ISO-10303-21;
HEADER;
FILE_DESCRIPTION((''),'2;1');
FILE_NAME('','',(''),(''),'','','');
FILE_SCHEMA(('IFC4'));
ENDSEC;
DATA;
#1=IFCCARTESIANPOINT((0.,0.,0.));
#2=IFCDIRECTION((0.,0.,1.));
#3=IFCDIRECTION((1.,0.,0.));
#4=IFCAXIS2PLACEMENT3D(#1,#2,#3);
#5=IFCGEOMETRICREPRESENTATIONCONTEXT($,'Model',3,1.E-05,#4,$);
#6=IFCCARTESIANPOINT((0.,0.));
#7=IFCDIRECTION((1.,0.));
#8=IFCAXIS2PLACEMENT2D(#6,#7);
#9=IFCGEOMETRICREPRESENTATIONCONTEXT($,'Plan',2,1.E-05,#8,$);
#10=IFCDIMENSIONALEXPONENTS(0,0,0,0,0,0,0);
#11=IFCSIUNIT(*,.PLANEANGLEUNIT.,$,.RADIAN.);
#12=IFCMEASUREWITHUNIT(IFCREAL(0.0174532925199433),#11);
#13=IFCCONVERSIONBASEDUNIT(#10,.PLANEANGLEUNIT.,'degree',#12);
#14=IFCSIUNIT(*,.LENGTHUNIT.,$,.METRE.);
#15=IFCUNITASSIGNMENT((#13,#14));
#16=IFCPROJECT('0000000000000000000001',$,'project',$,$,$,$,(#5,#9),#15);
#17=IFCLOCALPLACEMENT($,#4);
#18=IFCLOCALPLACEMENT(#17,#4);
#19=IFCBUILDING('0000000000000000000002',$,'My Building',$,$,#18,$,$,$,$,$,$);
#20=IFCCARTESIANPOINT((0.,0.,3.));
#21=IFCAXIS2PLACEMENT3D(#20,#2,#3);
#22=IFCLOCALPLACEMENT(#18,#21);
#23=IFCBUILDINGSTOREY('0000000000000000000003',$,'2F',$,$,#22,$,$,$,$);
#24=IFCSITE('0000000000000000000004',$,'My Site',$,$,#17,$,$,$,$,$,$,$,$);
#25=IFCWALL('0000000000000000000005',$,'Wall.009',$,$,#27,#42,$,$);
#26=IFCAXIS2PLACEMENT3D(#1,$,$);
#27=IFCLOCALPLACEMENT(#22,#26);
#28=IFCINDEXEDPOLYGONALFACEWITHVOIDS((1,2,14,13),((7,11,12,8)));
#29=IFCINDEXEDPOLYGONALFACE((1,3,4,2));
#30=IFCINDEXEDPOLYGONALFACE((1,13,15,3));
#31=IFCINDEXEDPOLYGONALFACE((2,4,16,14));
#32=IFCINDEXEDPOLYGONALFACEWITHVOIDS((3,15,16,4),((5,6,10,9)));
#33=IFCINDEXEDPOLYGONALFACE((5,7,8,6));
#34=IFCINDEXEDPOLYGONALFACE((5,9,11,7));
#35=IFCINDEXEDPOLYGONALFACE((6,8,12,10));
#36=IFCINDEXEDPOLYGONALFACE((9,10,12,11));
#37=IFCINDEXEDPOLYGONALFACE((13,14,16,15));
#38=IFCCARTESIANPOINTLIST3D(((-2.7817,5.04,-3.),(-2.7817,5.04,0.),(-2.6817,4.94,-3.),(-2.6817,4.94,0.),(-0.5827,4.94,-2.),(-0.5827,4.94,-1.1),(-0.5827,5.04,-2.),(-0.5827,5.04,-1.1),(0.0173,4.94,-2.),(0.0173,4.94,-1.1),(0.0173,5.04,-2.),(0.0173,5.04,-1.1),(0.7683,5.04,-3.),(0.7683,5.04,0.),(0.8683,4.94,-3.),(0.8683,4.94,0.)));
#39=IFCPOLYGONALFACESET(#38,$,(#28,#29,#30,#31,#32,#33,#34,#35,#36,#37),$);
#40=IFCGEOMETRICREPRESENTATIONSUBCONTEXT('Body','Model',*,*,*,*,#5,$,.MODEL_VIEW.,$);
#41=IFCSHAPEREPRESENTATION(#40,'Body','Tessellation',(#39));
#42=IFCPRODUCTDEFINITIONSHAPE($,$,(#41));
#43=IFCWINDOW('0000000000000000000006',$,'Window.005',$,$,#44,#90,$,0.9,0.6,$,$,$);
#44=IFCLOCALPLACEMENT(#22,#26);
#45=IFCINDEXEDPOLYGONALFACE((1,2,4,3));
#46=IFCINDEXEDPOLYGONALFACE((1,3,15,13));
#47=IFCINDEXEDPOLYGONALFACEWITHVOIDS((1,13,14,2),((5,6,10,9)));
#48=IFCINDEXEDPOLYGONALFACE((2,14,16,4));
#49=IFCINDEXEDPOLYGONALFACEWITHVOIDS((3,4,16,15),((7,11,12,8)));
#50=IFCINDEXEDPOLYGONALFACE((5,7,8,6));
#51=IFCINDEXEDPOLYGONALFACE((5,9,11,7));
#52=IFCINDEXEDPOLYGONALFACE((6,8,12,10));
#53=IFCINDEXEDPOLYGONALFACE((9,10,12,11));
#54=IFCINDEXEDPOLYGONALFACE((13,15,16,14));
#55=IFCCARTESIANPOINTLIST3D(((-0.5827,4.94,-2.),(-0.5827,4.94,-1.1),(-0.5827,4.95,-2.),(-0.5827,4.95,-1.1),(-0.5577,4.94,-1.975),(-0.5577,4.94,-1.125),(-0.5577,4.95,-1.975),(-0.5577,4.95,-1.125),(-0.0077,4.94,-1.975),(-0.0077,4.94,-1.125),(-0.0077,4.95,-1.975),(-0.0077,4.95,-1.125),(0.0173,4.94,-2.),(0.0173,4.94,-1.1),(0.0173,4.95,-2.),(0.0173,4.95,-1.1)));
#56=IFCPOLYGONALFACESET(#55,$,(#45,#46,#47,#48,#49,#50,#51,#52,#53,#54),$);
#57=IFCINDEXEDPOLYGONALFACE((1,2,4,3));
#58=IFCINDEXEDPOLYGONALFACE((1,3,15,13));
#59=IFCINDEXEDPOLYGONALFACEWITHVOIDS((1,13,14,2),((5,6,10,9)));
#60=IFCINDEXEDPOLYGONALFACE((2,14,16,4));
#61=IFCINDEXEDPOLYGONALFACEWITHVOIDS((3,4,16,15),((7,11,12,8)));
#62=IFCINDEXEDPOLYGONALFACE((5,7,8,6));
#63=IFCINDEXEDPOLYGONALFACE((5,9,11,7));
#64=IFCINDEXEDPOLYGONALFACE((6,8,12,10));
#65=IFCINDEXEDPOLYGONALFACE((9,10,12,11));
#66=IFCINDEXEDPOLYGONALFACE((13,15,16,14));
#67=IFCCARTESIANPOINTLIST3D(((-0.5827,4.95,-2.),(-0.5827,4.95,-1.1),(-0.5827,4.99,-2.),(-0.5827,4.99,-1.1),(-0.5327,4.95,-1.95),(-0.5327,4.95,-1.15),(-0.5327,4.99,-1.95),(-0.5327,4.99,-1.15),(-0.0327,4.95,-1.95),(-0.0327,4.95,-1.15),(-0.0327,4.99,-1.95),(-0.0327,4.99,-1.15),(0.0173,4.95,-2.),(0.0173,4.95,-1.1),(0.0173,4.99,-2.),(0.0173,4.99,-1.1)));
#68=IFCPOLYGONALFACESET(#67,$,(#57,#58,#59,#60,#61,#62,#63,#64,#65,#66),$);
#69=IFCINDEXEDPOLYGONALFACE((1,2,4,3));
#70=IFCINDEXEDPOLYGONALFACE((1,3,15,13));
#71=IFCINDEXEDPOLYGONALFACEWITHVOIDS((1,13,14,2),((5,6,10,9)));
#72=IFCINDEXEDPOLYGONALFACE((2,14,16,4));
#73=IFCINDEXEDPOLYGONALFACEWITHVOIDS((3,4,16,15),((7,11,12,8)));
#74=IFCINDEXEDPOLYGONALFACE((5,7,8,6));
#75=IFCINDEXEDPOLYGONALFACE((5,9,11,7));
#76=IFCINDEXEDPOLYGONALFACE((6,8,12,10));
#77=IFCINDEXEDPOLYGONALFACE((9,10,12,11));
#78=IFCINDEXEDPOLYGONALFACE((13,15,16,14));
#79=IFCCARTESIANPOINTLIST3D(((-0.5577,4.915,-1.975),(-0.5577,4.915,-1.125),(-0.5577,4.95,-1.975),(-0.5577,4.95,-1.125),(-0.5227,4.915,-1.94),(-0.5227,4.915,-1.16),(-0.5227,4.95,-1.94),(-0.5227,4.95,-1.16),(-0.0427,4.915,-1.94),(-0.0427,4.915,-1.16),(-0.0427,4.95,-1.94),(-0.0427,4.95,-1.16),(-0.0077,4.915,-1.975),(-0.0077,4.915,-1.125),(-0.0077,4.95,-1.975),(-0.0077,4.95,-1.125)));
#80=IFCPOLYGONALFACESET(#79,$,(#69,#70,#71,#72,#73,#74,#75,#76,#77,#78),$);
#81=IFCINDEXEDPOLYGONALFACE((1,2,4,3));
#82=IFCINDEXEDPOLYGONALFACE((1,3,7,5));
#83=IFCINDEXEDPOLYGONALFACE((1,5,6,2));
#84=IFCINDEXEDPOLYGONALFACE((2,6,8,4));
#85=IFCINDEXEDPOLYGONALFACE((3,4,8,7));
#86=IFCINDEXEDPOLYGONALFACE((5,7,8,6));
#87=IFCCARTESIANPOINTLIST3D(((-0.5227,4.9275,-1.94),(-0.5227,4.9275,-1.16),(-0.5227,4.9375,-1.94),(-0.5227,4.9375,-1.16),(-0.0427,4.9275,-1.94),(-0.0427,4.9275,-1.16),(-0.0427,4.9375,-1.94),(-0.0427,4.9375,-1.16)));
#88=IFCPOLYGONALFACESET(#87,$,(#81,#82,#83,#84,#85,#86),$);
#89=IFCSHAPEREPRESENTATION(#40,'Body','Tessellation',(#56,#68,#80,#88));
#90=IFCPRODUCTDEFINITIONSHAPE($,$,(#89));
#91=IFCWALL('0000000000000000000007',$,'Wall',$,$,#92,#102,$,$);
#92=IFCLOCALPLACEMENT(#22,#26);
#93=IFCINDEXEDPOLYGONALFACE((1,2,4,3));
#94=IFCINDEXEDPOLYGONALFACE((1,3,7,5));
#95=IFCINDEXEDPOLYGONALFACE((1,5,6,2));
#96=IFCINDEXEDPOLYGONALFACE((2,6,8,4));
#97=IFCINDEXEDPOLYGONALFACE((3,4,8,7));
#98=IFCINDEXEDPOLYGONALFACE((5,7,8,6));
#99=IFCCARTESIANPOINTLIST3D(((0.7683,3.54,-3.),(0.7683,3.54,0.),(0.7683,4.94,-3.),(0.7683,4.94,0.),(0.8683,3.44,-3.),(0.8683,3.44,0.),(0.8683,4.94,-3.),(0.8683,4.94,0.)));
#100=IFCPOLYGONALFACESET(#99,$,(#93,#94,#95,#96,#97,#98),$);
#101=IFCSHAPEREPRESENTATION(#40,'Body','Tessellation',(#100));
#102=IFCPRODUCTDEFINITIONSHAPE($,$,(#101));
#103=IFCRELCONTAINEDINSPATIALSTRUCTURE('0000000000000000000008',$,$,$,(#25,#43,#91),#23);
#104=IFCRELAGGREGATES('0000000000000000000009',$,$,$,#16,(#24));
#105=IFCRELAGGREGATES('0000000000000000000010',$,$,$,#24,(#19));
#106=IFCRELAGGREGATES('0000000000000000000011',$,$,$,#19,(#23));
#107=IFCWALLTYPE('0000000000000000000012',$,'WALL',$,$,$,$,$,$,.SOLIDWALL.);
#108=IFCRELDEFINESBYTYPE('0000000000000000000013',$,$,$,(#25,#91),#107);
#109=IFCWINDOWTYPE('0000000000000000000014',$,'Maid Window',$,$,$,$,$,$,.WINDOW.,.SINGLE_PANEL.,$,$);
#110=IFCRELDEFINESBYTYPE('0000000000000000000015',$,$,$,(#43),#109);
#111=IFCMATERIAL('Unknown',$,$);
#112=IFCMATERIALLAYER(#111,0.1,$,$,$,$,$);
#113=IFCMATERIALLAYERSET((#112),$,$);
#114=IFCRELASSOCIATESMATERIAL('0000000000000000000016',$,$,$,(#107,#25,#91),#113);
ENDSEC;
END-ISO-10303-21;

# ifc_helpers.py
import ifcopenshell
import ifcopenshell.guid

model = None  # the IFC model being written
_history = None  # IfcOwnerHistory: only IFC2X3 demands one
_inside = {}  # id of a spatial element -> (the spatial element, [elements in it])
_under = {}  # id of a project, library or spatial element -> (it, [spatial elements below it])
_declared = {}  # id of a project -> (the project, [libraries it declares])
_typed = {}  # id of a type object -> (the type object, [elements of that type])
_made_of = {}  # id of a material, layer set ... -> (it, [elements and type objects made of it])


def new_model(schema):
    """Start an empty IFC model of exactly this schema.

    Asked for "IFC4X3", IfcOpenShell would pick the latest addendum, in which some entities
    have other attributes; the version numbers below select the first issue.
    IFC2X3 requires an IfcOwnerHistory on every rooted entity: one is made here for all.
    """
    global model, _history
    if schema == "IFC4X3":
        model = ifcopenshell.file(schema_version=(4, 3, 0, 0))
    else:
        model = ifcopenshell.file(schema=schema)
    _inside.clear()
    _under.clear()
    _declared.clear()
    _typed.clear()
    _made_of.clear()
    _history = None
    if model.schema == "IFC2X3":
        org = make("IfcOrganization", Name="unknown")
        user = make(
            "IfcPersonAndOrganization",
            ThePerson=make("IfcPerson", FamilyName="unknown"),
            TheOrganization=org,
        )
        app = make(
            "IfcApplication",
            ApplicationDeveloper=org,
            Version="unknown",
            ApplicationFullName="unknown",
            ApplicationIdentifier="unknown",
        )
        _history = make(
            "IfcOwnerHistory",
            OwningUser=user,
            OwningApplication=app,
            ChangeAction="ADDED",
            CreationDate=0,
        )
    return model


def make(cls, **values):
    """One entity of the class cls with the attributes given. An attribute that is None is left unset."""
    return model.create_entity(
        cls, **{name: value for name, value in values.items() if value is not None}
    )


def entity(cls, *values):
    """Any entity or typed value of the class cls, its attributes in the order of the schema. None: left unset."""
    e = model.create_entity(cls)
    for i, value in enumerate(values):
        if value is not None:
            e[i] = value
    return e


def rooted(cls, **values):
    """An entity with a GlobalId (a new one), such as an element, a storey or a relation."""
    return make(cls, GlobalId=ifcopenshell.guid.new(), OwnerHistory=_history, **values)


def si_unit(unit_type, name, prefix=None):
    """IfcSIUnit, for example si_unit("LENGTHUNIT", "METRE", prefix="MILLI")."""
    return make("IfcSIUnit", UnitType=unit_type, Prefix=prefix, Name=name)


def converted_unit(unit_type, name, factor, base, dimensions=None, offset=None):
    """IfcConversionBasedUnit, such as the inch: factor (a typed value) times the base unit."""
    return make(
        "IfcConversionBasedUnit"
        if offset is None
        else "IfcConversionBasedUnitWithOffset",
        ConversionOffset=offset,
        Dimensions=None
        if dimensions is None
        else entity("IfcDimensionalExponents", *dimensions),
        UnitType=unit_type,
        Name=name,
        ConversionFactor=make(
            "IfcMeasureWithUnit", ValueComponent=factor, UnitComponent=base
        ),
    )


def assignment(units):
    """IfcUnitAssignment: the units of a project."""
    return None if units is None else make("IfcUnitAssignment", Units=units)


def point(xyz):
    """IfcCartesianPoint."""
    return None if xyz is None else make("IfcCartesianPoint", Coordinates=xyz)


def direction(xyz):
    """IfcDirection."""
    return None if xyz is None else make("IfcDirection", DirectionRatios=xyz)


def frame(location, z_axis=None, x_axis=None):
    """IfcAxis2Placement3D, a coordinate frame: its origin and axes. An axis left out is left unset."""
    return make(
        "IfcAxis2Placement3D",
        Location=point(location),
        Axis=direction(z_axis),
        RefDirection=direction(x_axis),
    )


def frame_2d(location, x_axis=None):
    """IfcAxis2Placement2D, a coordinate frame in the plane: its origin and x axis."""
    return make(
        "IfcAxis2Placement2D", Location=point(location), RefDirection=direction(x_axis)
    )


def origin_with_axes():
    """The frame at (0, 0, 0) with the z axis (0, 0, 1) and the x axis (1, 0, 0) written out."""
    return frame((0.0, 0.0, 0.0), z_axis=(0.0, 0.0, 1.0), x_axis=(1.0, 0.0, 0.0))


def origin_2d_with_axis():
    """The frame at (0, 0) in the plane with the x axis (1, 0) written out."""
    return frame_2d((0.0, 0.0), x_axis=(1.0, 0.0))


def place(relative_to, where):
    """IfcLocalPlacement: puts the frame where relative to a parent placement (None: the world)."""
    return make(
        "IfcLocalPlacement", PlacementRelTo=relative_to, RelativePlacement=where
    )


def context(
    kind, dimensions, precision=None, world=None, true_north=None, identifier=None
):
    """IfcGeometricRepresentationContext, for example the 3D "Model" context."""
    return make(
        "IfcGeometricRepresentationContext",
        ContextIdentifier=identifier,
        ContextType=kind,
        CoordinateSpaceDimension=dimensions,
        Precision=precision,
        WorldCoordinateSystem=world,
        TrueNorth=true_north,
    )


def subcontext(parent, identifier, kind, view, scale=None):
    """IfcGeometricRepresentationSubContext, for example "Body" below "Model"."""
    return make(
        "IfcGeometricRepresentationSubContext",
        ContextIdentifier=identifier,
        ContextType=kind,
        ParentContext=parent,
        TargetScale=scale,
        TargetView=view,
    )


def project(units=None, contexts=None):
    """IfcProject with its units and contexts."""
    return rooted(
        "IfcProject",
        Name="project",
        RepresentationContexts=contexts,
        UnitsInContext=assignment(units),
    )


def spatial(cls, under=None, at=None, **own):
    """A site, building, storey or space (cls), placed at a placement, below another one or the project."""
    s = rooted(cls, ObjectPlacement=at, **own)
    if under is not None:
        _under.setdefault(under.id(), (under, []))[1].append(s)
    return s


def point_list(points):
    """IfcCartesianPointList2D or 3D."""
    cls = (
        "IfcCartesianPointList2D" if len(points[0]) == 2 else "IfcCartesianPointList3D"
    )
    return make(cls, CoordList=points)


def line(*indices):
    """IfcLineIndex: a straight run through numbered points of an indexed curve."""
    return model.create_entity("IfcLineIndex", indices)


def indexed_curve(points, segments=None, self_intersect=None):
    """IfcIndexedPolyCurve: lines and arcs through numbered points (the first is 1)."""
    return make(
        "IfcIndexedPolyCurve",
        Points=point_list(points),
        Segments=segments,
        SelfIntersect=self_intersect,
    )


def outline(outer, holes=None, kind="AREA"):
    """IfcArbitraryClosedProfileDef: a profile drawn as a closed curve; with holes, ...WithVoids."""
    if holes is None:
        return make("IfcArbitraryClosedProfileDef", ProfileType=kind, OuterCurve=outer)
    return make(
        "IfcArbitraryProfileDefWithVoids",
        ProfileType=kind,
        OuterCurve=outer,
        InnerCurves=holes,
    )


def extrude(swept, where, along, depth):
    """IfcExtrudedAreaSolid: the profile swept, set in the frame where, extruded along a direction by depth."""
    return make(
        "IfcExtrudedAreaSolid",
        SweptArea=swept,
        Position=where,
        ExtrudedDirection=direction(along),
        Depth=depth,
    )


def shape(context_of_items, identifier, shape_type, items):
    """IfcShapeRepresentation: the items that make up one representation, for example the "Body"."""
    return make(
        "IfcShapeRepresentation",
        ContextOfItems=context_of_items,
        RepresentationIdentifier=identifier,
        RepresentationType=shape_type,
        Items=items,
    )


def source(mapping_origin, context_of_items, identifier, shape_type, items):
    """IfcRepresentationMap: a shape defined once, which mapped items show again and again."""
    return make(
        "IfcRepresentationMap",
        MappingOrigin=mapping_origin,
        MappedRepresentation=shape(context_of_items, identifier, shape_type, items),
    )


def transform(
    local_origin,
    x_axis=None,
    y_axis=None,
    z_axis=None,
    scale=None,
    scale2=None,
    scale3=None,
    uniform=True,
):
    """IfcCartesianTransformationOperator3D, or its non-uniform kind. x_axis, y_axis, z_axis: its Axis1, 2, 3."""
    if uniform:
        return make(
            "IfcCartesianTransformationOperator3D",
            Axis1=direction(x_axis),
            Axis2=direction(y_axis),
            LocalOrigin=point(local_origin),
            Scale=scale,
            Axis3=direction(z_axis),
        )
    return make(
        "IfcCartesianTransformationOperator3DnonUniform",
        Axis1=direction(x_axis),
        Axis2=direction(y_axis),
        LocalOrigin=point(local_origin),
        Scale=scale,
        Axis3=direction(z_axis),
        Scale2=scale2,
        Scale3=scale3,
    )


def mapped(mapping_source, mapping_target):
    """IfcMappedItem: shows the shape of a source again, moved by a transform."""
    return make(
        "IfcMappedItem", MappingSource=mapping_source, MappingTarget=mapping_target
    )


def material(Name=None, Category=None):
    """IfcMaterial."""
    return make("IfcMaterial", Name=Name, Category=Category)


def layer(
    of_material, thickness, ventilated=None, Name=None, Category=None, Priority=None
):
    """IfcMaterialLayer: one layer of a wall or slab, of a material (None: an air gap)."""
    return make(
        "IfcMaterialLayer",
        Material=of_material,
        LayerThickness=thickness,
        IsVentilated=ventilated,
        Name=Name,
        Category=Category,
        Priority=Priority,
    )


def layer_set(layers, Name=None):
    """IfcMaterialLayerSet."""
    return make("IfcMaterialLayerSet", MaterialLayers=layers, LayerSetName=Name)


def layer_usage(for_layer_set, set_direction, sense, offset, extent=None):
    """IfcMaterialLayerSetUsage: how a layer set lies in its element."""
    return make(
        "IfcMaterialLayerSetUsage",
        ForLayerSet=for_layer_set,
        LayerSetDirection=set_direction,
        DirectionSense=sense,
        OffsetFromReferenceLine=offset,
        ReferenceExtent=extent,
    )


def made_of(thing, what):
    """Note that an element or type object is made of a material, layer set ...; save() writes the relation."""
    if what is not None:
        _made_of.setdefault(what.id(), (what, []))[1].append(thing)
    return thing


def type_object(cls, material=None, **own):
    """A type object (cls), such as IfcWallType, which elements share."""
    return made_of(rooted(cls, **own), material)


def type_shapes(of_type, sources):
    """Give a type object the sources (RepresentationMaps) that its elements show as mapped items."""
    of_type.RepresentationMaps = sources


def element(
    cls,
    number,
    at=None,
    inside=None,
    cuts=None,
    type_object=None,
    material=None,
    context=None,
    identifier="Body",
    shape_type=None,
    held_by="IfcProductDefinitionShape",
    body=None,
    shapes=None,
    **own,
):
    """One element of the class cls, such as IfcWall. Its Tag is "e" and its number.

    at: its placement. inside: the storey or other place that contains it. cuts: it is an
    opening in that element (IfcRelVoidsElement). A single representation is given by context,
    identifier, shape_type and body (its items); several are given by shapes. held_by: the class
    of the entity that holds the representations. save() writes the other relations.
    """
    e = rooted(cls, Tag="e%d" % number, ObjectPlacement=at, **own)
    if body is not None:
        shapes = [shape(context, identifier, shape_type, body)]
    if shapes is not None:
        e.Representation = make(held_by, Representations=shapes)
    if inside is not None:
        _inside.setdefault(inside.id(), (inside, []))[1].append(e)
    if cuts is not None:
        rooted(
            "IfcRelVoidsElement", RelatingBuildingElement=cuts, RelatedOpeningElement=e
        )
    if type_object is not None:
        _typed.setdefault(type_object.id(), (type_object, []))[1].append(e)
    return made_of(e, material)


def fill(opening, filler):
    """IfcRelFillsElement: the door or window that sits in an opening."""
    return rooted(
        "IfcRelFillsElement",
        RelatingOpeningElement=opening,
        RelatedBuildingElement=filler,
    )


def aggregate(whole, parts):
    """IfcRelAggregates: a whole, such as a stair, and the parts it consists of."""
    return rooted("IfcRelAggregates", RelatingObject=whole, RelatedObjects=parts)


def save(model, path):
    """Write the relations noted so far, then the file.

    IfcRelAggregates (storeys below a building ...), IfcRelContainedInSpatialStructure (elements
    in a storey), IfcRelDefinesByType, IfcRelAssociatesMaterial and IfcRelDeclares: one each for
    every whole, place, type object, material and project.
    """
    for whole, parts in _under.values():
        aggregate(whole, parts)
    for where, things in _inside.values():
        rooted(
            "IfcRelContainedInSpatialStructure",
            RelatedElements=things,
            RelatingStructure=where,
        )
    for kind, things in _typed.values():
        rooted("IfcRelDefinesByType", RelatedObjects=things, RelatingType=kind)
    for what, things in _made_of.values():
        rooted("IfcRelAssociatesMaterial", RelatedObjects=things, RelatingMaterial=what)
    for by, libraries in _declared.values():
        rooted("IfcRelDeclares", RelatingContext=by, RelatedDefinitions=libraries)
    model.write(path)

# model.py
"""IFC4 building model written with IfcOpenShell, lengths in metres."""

from ifc_helpers import new_model, entity, si_unit, converted_unit, frame, origin_with_axes, origin_2d_with_axis, place, context, subcontext, project, spatial, line, indexed_curve, outline, extrude, shape, source, transform, mapped, material, layer, layer_set, layer_usage, type_object, type_shapes, element, fill, save


model = new_model("IFC4")

# Units and contexts
model_context = context("Model", 3, precision=1e-05, world=origin_with_axes())
plan_context = context("Plan", 2, precision=1e-05, world=origin_2d_with_axis())
body_context_1 = subcontext(model_context, "Body", "Model", "MODEL_VIEW")
body_context_2 = subcontext(plan_context, "Body", "Plan", "PLAN_VIEW")
ifc_project = project(units=[converted_unit("PLANEANGLEUNIT", "degree", entity("IfcReal", 0.0174532925199433), si_unit("PLANEANGLEUNIT", "RADIAN"), dimensions=[0, 0, 0, 0, 0, 0, 0]), si_unit("LENGTHUNIT", "METRE")], contexts=[model_context, plan_context])

# Site, building, storey
site_placement = place(None, origin_with_axes())
site = spatial("IfcSite", under=ifc_project, at=site_placement, Name="My Site")
building_placement = place(site_placement, origin_with_axes())
building = spatial("IfcBuilding", under=site, at=building_placement, Name="My Building")
storey_placement = place(building_placement, frame((0.0, 0.0, 3.0), z_axis=(0.0, 0.0, 1.0), x_axis=(1.0, 0.0, 0.0)))
storey = spatial("IfcBuildingStorey", under=building, at=storey_placement, Name="2F")

# Shared definitions
ifc_material = material(Name="Unknown")

# Shared definitions
ifc_layer_1 = layer(ifc_material, 0.1)
ifc_layer_set_1 = layer_set([ifc_layer_1])
wall_type_1 = type_object("IfcWallType", Name="WALL", PredefinedType="SOLIDWALL", material=ifc_layer_set_1)

# Wall, opening, window
ifc_layer_usage_1 = layer_usage(ifc_layer_set_1, "AXIS2", "POSITIVE", 0.0)
wall_1_placement = place(storey_placement, frame((0.7683, 5.04, -3.0), z_axis=(0.0, 0.0, 1.0), x_axis=(-1.0, 0.0, 0.0)))
wall_1 = element("IfcWall", 1, at=wall_1_placement, inside=storey, type_object=wall_type_1, material=ifc_layer_usage_1, Name="Wall.009", context=body_context_1, shape_type="SweptSolid", body=[
    extrude(outline(indexed_curve([(0.0, 0.0), (-0.1, 0.1), (3.45, 0.1), (3.55, 0.0)], segments=[line(1, 2, 3, 4, 1)])), origin_with_axes(), (0.0, 0.0, 1.0), 3.0),
])
shared_shape_1 = source(origin_with_axes(), body_context_1, "Body", "SweptSolid", [
    extrude(outline(indexed_curve([(0.0, 0.0), (0.6, 0.0), (0.6, 0.9), (0.0, 0.9)], segments=[line(1, 2, 3, 4, 1)])), frame((0.0, -0.6, 0.0), z_axis=(0.0, -1.0, 0.0), x_axis=(1.0, 0.0, 0.0)), (0.0, 0.0, -1.0), 1.2),
])
opening_1_placement = place(wall_1_placement, frame((0.751, 0.0, 1.0), z_axis=(0.0, 0.0, 1.0), x_axis=(1.0, 0.0, 0.0)))
opening_1 = element("IfcOpeningElement", 2, at=opening_1_placement, cuts=wall_1, PredefinedType="OPENING", context=body_context_1, shape_type="MappedRepresentation", body=[
    mapped(shared_shape_1, transform((0.0, 0.0, 0.0), x_axis=(1.0, 0.0, 0.0), y_axis=(0.0, 1.0, 0.0), z_axis=(0.0, 0.0, 1.0), scale=1.0)),
])
window_type_1 = type_object("IfcWindowType", Name="Maid Window", PartitioningType="SINGLE_PANEL", PredefinedType="WINDOW")
shared_shape_2 = source(origin_with_axes(), body_context_1, "Body", "SweptSolid", [
    extrude(outline(indexed_curve([(0.0, 0.0), (0.6, 0.0), (0.6, 0.9), (0.0, 0.9)], segments=[line(1, 2, 3, 4, 1)]), holes=[indexed_curve([(0.025, 0.025), (0.575, 0.025), (0.575, 0.875), (0.025, 0.875)], segments=[line(1, 2, 3, 4, 1)])]), frame((0.0, 0.09, 0.0), z_axis=(0.0, -1.0, 0.0), x_axis=(1.0, 0.0, 0.0)), (0.0, 0.0, -1.0), 0.01),
    extrude(outline(indexed_curve([(0.0, 0.0), (0.6, 0.0), (0.6, 0.9), (0.0, 0.9)], segments=[line(1, 2, 3, 4, 1)]), holes=[indexed_curve([(0.05, 0.05), (0.55, 0.05), (0.55, 0.85), (0.05, 0.85)], segments=[line(1, 2, 3, 4, 1)])]), frame((0.0, 0.05, 0.0), z_axis=(0.0, -1.0, 0.0), x_axis=(1.0, 0.0, 0.0)), (0.0, 0.0, -1.0), 0.04),
    extrude(outline(indexed_curve([(0.0, 0.0), (0.55, 0.0), (0.55, 0.85), (0.0, 0.85)], segments=[line(1, 2, 3, 4, 1)]), holes=[indexed_curve([(0.035, 0.035), (0.515, 0.035), (0.515, 0.815), (0.035, 0.815)], segments=[line(1, 2, 3, 4, 1)])]), frame((0.025, 0.09, 0.025), z_axis=(0.0, -1.0, 0.0), x_axis=(1.0, 0.0, 0.0)), (0.0, 0.0, -1.0), 0.035),
    extrude(outline(indexed_curve([(0.035, 0.035), (0.515, 0.035), (0.515, 0.815), (0.035, 0.815)], segments=[line(1, 2, 3, 4, 1)])), frame((0.025, 0.1025, 0.025), z_axis=(0.0, -1.0, 0.0), x_axis=(1.0, 0.0, 0.0)), (0.0, 0.0, -1.0), 0.01),
])
shared_shape_3 = source(origin_with_axes(), body_context_2, "Body", "Curve2D", [
    entity("IfcIndexedPolyCurve", entity("IfcCartesianPointList2D", [[0.05, 0.05], [0.55, 0.05]])),
    entity("IfcIndexedPolyCurve", entity("IfcCartesianPointList2D", [[0.0, 0.1], [0.025, 0.1], [0.025, 0.09], [0.05, 0.09], [0.05, 0.05], [0.0, 0.05]]), [entity("IfcLineIndex", [1, 2, 3, 4, 5, 6, 1])]),
    entity("IfcIndexedPolyCurve", entity("IfcCartesianPointList2D", [[0.6, 0.1], [0.575, 0.1], [0.575, 0.09], [0.55, 0.09], [0.55, 0.05], [0.6, 0.05]]), [entity("IfcLineIndex", [1, 2, 3, 4, 5, 6, 1])]),
    entity("IfcIndexedPolyCurve", entity("IfcCartesianPointList2D", [[0.025, 0.09], [0.06, 0.09], [0.06, 0.125], [0.025, 0.125]]), [entity("IfcLineIndex", [1, 2, 3, 4, 1])]),
    entity("IfcIndexedPolyCurve", entity("IfcCartesianPointList2D", [[0.575, 0.09], [0.54, 0.09], [0.54, 0.125], [0.575, 0.125]]), [entity("IfcLineIndex", [1, 2, 3, 4, 1])]),
    entity("IfcIndexedPolyCurve", entity("IfcCartesianPointList2D", [[0.06, 0.09], [0.54, 0.09]])),
    entity("IfcIndexedPolyCurve", entity("IfcCartesianPointList2D", [[0.06, 0.125], [0.54, 0.125]])),
    entity("IfcIndexedPolyCurve", entity("IfcCartesianPointList2D", [[0.06, 0.1075], [0.54, 0.1075]])),
])
type_shapes(window_type_1, [shared_shape_2, shared_shape_3])
window_1_placement = place(opening_1_placement, frame((0.0, 0.0, 0.0), z_axis=(0.0, 0.0, 1.0), x_axis=(1.0, 0.0, 0.0)))
window_1 = element("IfcWindow", 3, at=window_1_placement, inside=storey, type_object=window_type_1, Name="Window.005", OverallHeight=0.9, OverallWidth=0.6, shapes=[
    shape(body_context_1, "Body", "MappedRepresentation", [mapped(shared_shape_2, transform((0.0, 0.0, 0.0), x_axis=(1.0, 0.0, 0.0), y_axis=(0.0, 1.0, 0.0), z_axis=(0.0, 0.0, 1.0), scale=1.0))]),
    shape(body_context_2, "Body", "MappedRepresentation", [mapped(shared_shape_3, transform((0.0, 0.0, 0.0), x_axis=(1.0, 0.0, 0.0), y_axis=(0.0, 1.0, 0.0), z_axis=(0.0, 0.0, 1.0), scale=1.0))]),
])
fill(opening_1, window_1)

# Wall
ifc_layer_usage_2 = layer_usage(ifc_layer_set_1, "AXIS2", "POSITIVE", 0.0)
wall_2_placement = place(storey_placement, frame((0.7683, 4.94, -3.0), z_axis=(0.0, 0.0, 1.0), x_axis=(0.0, -1.0, 0.0)))
element("IfcWall", 4, at=wall_2_placement, inside=storey, type_object=wall_type_1, material=ifc_layer_usage_2, Name="Wall", context=body_context_1, shape_type="SweptSolid", body=[
    extrude(outline(indexed_curve([(0.0, 0.0), (0.0, 0.1), (1.5, 0.1), (1.4, 0.0)], segments=[line(1, 2, 3, 4, 1)])), origin_with_axes(), (0.0, 0.0, 1.0), 3.0),
])

save(model, "model.ifc")
